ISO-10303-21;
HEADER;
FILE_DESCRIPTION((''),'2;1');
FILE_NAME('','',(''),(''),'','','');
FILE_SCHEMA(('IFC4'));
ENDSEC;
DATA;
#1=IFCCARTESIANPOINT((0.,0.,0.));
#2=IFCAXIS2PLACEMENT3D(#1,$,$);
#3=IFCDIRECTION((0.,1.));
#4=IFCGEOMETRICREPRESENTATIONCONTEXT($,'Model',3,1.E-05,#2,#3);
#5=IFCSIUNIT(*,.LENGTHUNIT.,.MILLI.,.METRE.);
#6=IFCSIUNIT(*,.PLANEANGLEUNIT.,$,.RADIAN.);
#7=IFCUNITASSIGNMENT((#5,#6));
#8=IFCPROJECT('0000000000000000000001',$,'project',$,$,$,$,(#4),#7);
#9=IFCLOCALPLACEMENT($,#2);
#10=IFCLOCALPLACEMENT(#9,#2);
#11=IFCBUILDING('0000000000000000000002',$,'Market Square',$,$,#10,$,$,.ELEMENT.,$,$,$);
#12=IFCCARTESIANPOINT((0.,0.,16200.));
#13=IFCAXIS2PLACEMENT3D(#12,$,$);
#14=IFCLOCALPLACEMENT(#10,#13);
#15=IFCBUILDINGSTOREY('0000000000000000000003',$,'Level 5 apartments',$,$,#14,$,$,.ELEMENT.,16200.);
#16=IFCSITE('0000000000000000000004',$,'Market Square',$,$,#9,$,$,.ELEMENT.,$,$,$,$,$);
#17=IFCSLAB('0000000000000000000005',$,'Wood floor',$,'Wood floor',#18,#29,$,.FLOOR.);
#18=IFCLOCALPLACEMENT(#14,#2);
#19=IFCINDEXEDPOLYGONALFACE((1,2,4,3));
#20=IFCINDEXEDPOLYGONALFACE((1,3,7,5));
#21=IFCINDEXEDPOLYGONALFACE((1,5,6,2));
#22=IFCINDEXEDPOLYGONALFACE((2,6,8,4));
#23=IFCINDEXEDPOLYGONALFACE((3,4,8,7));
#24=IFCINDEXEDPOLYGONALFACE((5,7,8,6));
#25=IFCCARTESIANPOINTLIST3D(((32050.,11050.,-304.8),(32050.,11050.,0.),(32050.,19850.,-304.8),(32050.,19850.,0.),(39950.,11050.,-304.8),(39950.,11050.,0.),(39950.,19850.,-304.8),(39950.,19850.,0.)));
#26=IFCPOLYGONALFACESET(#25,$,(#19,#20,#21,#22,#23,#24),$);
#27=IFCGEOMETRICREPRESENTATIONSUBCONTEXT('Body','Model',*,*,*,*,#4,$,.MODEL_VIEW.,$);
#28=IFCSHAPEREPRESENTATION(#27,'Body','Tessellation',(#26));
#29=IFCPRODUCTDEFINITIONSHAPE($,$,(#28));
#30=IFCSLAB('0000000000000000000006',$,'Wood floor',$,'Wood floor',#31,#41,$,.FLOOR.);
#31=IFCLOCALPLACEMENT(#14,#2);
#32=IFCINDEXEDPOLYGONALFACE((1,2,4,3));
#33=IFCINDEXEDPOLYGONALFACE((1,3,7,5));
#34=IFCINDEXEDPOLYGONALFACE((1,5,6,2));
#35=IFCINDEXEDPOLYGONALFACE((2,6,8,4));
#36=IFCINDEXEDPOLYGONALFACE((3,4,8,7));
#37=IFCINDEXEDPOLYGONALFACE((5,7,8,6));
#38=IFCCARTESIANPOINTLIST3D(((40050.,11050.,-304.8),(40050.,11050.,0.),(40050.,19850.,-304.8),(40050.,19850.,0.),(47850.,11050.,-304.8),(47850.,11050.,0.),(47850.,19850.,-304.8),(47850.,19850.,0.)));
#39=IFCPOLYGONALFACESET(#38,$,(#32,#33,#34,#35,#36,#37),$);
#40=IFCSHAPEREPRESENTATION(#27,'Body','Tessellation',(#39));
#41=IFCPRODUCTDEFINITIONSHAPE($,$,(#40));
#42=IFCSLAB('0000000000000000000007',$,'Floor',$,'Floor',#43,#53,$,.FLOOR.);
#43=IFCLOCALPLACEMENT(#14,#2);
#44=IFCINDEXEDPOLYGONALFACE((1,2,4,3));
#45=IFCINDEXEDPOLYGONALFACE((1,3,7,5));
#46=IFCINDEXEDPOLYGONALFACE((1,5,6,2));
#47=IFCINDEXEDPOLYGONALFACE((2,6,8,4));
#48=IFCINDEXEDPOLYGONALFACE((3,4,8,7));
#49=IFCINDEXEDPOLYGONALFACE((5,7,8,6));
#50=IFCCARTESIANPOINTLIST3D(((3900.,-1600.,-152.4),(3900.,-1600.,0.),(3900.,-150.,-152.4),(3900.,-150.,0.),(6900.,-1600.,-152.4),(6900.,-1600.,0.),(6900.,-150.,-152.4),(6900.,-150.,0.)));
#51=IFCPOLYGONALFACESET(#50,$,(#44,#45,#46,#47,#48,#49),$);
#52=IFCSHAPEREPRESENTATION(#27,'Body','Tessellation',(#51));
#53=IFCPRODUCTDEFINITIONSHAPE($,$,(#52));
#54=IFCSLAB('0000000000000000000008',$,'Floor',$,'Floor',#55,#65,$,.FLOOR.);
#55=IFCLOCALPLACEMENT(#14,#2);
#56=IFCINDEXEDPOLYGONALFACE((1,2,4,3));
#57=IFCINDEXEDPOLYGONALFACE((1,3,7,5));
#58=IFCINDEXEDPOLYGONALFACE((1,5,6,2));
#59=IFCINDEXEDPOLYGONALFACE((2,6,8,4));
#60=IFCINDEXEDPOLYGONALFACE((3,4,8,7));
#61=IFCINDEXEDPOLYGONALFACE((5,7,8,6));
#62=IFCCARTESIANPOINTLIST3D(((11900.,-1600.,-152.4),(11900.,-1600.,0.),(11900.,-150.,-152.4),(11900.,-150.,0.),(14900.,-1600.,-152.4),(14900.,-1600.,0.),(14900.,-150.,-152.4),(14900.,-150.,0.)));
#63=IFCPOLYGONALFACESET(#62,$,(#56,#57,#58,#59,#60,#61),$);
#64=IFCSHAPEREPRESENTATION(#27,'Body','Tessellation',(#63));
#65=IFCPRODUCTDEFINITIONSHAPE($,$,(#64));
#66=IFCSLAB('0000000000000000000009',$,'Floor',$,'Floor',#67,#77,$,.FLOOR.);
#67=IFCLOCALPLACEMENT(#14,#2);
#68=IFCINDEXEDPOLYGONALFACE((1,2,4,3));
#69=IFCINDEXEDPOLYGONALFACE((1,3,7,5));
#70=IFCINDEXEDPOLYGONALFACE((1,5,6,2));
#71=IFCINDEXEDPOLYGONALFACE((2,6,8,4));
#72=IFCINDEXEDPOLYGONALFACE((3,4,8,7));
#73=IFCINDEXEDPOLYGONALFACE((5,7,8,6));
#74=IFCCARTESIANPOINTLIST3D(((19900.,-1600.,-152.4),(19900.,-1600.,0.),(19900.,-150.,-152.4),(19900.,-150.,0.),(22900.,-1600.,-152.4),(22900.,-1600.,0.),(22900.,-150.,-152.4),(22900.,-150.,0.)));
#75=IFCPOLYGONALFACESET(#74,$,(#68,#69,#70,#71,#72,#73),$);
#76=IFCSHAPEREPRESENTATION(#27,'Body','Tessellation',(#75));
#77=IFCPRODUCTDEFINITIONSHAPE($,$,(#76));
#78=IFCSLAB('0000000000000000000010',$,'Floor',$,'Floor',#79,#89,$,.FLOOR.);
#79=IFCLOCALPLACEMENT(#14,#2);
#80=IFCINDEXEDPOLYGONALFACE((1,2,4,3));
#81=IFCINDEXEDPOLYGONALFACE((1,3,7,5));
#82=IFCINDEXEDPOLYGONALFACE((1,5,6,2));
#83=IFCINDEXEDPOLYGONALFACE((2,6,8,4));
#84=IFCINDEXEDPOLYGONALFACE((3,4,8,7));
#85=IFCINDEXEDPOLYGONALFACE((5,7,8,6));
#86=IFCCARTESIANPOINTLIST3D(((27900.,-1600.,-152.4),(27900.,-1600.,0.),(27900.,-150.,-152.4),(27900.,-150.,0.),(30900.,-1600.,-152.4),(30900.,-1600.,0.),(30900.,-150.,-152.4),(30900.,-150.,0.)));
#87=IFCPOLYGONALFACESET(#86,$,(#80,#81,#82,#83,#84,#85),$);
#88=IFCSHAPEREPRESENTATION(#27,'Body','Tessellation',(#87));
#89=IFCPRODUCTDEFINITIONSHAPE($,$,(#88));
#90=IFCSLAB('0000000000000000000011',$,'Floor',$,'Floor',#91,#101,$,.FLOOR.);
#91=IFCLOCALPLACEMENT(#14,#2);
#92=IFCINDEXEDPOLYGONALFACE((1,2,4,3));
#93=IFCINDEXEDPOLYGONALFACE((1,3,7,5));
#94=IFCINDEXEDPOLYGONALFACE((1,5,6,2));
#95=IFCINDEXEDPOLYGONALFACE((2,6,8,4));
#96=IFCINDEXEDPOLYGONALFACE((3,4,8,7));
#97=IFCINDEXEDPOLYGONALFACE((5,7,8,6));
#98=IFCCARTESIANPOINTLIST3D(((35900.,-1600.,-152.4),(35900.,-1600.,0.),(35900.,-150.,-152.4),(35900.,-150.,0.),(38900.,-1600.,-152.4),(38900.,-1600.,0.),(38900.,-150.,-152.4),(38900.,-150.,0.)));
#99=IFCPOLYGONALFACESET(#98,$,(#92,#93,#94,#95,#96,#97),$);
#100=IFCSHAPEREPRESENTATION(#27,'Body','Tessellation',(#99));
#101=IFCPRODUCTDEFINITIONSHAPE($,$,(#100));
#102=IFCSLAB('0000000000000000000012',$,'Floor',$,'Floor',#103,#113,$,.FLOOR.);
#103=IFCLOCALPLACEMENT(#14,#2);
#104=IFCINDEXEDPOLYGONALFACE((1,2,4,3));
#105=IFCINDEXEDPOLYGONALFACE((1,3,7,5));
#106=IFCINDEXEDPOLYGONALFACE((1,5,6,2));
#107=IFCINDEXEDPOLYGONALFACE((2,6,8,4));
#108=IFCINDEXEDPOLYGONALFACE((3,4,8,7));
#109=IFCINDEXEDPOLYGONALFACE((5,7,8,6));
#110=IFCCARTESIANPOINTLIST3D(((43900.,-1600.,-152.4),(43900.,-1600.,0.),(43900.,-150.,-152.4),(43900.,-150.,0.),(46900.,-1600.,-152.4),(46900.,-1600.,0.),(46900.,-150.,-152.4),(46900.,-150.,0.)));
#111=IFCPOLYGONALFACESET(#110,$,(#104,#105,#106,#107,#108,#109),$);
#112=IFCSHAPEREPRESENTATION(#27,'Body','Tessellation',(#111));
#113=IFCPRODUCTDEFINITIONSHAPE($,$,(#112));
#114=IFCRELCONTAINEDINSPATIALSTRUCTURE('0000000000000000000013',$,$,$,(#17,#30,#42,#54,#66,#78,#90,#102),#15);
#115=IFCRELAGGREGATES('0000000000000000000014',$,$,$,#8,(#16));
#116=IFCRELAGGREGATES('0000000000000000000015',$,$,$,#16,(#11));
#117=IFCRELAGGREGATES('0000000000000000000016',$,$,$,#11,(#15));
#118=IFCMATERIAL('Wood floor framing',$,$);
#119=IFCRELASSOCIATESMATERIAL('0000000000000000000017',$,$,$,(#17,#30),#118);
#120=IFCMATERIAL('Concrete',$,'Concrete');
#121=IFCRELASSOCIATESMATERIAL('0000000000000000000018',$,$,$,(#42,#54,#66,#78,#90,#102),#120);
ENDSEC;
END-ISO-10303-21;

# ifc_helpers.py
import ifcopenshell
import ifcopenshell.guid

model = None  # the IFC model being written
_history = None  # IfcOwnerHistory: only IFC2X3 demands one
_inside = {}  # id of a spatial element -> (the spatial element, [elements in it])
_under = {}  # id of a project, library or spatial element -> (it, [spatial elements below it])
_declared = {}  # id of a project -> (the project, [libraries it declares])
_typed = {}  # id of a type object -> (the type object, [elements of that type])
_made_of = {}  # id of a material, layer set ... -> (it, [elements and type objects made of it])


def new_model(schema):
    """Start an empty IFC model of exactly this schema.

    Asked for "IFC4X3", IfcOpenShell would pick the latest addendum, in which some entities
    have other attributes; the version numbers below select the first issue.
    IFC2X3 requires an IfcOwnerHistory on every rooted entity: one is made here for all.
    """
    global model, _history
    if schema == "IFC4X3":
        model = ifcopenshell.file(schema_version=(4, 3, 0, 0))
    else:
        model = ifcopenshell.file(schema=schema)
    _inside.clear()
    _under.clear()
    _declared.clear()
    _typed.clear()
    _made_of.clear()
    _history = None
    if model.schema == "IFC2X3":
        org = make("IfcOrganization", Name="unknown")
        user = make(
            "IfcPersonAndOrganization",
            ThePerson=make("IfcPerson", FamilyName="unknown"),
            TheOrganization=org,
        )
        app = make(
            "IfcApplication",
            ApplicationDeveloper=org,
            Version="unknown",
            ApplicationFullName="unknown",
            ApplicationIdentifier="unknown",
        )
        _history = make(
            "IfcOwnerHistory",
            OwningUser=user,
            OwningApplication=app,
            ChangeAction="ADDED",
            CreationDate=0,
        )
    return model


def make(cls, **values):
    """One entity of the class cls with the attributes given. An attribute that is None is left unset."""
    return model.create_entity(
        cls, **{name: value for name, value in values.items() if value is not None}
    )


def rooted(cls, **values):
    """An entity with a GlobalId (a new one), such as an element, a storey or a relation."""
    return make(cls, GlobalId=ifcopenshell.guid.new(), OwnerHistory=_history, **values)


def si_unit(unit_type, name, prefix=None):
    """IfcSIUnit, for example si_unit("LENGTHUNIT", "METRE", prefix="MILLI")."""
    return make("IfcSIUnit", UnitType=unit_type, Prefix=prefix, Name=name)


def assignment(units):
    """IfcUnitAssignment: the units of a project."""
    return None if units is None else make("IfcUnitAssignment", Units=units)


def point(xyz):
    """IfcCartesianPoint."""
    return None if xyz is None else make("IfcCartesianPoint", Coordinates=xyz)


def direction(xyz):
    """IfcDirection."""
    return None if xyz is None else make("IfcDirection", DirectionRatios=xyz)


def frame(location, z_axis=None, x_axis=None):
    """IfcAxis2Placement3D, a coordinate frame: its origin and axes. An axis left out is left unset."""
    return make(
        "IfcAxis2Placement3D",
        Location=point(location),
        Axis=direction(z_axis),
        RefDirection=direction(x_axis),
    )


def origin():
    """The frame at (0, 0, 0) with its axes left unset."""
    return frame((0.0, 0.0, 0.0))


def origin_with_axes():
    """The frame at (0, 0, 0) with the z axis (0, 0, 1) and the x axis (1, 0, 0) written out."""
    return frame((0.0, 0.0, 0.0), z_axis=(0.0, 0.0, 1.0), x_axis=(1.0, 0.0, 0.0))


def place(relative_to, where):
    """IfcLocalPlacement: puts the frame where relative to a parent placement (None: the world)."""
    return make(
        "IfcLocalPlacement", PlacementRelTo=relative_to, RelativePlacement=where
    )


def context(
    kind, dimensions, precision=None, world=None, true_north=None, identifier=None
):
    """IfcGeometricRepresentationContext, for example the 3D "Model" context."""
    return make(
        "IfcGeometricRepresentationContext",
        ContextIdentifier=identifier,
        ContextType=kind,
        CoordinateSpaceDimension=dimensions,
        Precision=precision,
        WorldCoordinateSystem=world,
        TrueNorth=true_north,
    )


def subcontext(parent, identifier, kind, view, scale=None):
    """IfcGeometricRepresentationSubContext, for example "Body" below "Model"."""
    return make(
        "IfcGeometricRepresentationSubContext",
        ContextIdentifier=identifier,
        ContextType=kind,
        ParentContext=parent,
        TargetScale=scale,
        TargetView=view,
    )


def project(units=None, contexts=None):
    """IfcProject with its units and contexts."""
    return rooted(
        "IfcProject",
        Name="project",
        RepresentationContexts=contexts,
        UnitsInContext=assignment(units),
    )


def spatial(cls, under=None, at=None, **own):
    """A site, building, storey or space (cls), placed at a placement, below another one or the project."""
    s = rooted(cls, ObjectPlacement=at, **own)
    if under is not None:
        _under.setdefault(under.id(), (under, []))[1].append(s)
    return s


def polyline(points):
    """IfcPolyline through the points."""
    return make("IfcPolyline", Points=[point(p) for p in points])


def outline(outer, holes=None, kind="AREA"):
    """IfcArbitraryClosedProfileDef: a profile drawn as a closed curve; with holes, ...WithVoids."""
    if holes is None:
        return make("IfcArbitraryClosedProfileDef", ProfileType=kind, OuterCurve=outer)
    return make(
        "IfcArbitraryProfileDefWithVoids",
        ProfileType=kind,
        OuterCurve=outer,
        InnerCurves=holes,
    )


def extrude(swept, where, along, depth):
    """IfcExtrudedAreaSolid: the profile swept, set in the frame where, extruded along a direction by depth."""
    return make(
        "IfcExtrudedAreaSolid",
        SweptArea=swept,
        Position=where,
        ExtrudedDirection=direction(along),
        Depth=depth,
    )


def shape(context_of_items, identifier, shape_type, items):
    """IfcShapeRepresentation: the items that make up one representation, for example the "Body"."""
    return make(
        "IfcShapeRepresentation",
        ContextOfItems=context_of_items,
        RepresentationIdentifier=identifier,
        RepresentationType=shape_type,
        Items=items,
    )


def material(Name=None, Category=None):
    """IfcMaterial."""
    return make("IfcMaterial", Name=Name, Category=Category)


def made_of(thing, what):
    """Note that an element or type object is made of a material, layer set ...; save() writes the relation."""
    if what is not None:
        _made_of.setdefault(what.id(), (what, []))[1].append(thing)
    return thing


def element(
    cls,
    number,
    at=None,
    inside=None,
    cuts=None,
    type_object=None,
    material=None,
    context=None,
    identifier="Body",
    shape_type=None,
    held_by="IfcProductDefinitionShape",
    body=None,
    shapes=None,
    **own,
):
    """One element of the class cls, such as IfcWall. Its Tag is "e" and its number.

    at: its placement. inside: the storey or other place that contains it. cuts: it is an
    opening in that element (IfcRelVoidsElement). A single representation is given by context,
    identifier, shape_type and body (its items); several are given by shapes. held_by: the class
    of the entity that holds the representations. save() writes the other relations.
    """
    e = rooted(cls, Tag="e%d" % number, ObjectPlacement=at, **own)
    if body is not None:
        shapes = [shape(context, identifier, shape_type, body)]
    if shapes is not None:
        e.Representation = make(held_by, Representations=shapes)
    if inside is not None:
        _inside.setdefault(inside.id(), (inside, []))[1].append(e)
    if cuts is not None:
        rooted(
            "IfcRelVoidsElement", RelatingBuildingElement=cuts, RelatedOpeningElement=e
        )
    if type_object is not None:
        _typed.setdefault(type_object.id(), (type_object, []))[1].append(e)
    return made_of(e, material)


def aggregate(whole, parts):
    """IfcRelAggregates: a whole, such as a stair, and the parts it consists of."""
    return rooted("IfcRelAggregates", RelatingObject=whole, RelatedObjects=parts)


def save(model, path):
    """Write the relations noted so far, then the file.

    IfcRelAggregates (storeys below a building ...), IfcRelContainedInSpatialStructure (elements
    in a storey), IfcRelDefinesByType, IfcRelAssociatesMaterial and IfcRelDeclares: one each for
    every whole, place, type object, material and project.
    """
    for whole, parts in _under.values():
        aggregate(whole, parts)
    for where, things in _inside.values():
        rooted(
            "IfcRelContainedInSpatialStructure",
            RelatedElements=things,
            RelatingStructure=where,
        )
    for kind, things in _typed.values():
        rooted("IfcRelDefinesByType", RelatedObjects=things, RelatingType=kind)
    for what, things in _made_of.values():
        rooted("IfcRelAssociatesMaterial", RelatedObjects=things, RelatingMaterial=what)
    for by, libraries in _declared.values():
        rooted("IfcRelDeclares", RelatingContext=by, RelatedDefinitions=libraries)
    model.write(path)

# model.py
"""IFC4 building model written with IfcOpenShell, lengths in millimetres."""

from ifc_helpers import new_model, si_unit, direction, frame, origin, origin_with_axes, place, context, subcontext, project, spatial, polyline, outline, extrude, material, element, save


model = new_model("IFC4")

# Units and contexts
model_context = context("Model", 3, precision=1e-05, world=origin(), true_north=direction((0.0, 1.0)))
body_context = subcontext(model_context, "Body", "Model", "MODEL_VIEW")
ifc_project = project(units=[si_unit("LENGTHUNIT", "METRE", prefix="MILLI"), si_unit("PLANEANGLEUNIT", "RADIAN")], contexts=[model_context])

# Site, building, storey
site_placement = place(None, origin())
site = spatial("IfcSite", under=ifc_project, at=site_placement, Name="Market Square", CompositionType="ELEMENT")
building_placement = place(site_placement, origin())
building = spatial("IfcBuilding", under=site, at=building_placement, Name="Market Square", CompositionType="ELEMENT")
storey_placement = place(building_placement, frame((0.0, 0.0, 16200.0)))
storey = spatial("IfcBuildingStorey", under=building, at=storey_placement, Name="Level 5 apartments", CompositionType="ELEMENT", Elevation=16200.0)

# Slabs
ifc_material_1 = material(Name="Wood floor framing")
slab_1_placement = place(storey_placement, origin_with_axes())
element("IfcSlab", 1, at=slab_1_placement, inside=storey, material=ifc_material_1, Name="Wood floor", ObjectType="Wood floor", PredefinedType="FLOOR", context=body_context, shape_type="SweptSolid", body=[
    extrude(outline(polyline([(39950.0, 19850.0), (32050.0, 19850.0), (32050.0, 11050.0), (39950.0, 11050.0), (39950.0, 19850.0)])), frame((0.0, 0.0, -304.8)), (0.0, 0.0, 1.0), 304.8),
])
slab_2_placement = place(storey_placement, origin_with_axes())
element("IfcSlab", 2, at=slab_2_placement, inside=storey, material=ifc_material_1, Name="Wood floor", ObjectType="Wood floor", PredefinedType="FLOOR", context=body_context, shape_type="SweptSolid", body=[
    extrude(outline(polyline([(47850.0, 11050.0), (47850.0, 19850.0), (40050.0, 19850.0), (40050.0, 11050.0), (47850.0, 11050.0)])), frame((0.0, 0.0, -304.8)), (0.0, 0.0, 1.0), 304.8),
])
ifc_material_2 = material(Name="Concrete", Category="Concrete")
slab_3_placement = place(storey_placement, origin_with_axes())
element("IfcSlab", 3, at=slab_3_placement, inside=storey, material=ifc_material_2, Name="Floor", ObjectType="Floor", PredefinedType="FLOOR", context=body_context, shape_type="SweptSolid", body=[
    extrude(outline(polyline([(3900.0, -1600.0), (6900.0, -1600.0), (6900.0, -150.0), (3900.0, -150.0), (3900.0, -1600.0)])), frame((0.0, 0.0, -152.4)), (0.0, 0.0, 1.0), 152.4),
])
slab_4_placement = place(storey_placement, origin_with_axes())
element("IfcSlab", 4, at=slab_4_placement, inside=storey, material=ifc_material_2, Name="Floor", ObjectType="Floor", PredefinedType="FLOOR", context=body_context, shape_type="SweptSolid", body=[
    extrude(outline(polyline([(11900.0, -1600.0), (14900.0, -1600.0), (14900.0, -150.0), (11900.0, -150.0), (11900.0, -1600.0)])), frame((0.0, 0.0, -152.4)), (0.0, 0.0, 1.0), 152.4),
])
slab_5_placement = place(storey_placement, origin_with_axes())
element("IfcSlab", 5, at=slab_5_placement, inside=storey, material=ifc_material_2, Name="Floor", ObjectType="Floor", PredefinedType="FLOOR", context=body_context, shape_type="SweptSolid", body=[
    extrude(outline(polyline([(19900.0, -1600.0), (22900.0, -1600.0), (22900.0, -150.0), (19900.0, -150.0), (19900.0, -1600.0)])), frame((0.0, 0.0, -152.4)), (0.0, 0.0, 1.0), 152.4),
])
slab_6_placement = place(storey_placement, origin_with_axes())
element("IfcSlab", 6, at=slab_6_placement, inside=storey, material=ifc_material_2, Name="Floor", ObjectType="Floor", PredefinedType="FLOOR", context=body_context, shape_type="SweptSolid", body=[
    extrude(outline(polyline([(27900.0, -1600.0), (30900.0, -1600.0), (30900.0, -150.0), (27900.0, -150.0), (27900.0, -1600.0)])), frame((0.0, 0.0, -152.4)), (0.0, 0.0, 1.0), 152.4),
])
slab_7_placement = place(storey_placement, origin_with_axes())
element("IfcSlab", 7, at=slab_7_placement, inside=storey, material=ifc_material_2, Name="Floor", ObjectType="Floor", PredefinedType="FLOOR", context=body_context, shape_type="SweptSolid", body=[
    extrude(outline(polyline([(35900.0, -1600.0), (38900.0, -1600.0), (38900.0, -150.0), (35900.0, -150.0), (35900.0, -1600.0)])), frame((0.0, 0.0, -152.4)), (0.0, 0.0, 1.0), 152.4),
])
slab_8_placement = place(storey_placement, origin_with_axes())
element("IfcSlab", 8, at=slab_8_placement, inside=storey, material=ifc_material_2, Name="Floor", ObjectType="Floor", PredefinedType="FLOOR", context=body_context, shape_type="SweptSolid", body=[
    extrude(outline(polyline([(43900.0, -1600.0), (46900.0, -1600.0), (46900.0, -150.0), (43900.0, -150.0), (43900.0, -1600.0)])), frame((0.0, 0.0, -152.4)), (0.0, 0.0, 1.0), 152.4),
])

save(model, "model.ifc")
